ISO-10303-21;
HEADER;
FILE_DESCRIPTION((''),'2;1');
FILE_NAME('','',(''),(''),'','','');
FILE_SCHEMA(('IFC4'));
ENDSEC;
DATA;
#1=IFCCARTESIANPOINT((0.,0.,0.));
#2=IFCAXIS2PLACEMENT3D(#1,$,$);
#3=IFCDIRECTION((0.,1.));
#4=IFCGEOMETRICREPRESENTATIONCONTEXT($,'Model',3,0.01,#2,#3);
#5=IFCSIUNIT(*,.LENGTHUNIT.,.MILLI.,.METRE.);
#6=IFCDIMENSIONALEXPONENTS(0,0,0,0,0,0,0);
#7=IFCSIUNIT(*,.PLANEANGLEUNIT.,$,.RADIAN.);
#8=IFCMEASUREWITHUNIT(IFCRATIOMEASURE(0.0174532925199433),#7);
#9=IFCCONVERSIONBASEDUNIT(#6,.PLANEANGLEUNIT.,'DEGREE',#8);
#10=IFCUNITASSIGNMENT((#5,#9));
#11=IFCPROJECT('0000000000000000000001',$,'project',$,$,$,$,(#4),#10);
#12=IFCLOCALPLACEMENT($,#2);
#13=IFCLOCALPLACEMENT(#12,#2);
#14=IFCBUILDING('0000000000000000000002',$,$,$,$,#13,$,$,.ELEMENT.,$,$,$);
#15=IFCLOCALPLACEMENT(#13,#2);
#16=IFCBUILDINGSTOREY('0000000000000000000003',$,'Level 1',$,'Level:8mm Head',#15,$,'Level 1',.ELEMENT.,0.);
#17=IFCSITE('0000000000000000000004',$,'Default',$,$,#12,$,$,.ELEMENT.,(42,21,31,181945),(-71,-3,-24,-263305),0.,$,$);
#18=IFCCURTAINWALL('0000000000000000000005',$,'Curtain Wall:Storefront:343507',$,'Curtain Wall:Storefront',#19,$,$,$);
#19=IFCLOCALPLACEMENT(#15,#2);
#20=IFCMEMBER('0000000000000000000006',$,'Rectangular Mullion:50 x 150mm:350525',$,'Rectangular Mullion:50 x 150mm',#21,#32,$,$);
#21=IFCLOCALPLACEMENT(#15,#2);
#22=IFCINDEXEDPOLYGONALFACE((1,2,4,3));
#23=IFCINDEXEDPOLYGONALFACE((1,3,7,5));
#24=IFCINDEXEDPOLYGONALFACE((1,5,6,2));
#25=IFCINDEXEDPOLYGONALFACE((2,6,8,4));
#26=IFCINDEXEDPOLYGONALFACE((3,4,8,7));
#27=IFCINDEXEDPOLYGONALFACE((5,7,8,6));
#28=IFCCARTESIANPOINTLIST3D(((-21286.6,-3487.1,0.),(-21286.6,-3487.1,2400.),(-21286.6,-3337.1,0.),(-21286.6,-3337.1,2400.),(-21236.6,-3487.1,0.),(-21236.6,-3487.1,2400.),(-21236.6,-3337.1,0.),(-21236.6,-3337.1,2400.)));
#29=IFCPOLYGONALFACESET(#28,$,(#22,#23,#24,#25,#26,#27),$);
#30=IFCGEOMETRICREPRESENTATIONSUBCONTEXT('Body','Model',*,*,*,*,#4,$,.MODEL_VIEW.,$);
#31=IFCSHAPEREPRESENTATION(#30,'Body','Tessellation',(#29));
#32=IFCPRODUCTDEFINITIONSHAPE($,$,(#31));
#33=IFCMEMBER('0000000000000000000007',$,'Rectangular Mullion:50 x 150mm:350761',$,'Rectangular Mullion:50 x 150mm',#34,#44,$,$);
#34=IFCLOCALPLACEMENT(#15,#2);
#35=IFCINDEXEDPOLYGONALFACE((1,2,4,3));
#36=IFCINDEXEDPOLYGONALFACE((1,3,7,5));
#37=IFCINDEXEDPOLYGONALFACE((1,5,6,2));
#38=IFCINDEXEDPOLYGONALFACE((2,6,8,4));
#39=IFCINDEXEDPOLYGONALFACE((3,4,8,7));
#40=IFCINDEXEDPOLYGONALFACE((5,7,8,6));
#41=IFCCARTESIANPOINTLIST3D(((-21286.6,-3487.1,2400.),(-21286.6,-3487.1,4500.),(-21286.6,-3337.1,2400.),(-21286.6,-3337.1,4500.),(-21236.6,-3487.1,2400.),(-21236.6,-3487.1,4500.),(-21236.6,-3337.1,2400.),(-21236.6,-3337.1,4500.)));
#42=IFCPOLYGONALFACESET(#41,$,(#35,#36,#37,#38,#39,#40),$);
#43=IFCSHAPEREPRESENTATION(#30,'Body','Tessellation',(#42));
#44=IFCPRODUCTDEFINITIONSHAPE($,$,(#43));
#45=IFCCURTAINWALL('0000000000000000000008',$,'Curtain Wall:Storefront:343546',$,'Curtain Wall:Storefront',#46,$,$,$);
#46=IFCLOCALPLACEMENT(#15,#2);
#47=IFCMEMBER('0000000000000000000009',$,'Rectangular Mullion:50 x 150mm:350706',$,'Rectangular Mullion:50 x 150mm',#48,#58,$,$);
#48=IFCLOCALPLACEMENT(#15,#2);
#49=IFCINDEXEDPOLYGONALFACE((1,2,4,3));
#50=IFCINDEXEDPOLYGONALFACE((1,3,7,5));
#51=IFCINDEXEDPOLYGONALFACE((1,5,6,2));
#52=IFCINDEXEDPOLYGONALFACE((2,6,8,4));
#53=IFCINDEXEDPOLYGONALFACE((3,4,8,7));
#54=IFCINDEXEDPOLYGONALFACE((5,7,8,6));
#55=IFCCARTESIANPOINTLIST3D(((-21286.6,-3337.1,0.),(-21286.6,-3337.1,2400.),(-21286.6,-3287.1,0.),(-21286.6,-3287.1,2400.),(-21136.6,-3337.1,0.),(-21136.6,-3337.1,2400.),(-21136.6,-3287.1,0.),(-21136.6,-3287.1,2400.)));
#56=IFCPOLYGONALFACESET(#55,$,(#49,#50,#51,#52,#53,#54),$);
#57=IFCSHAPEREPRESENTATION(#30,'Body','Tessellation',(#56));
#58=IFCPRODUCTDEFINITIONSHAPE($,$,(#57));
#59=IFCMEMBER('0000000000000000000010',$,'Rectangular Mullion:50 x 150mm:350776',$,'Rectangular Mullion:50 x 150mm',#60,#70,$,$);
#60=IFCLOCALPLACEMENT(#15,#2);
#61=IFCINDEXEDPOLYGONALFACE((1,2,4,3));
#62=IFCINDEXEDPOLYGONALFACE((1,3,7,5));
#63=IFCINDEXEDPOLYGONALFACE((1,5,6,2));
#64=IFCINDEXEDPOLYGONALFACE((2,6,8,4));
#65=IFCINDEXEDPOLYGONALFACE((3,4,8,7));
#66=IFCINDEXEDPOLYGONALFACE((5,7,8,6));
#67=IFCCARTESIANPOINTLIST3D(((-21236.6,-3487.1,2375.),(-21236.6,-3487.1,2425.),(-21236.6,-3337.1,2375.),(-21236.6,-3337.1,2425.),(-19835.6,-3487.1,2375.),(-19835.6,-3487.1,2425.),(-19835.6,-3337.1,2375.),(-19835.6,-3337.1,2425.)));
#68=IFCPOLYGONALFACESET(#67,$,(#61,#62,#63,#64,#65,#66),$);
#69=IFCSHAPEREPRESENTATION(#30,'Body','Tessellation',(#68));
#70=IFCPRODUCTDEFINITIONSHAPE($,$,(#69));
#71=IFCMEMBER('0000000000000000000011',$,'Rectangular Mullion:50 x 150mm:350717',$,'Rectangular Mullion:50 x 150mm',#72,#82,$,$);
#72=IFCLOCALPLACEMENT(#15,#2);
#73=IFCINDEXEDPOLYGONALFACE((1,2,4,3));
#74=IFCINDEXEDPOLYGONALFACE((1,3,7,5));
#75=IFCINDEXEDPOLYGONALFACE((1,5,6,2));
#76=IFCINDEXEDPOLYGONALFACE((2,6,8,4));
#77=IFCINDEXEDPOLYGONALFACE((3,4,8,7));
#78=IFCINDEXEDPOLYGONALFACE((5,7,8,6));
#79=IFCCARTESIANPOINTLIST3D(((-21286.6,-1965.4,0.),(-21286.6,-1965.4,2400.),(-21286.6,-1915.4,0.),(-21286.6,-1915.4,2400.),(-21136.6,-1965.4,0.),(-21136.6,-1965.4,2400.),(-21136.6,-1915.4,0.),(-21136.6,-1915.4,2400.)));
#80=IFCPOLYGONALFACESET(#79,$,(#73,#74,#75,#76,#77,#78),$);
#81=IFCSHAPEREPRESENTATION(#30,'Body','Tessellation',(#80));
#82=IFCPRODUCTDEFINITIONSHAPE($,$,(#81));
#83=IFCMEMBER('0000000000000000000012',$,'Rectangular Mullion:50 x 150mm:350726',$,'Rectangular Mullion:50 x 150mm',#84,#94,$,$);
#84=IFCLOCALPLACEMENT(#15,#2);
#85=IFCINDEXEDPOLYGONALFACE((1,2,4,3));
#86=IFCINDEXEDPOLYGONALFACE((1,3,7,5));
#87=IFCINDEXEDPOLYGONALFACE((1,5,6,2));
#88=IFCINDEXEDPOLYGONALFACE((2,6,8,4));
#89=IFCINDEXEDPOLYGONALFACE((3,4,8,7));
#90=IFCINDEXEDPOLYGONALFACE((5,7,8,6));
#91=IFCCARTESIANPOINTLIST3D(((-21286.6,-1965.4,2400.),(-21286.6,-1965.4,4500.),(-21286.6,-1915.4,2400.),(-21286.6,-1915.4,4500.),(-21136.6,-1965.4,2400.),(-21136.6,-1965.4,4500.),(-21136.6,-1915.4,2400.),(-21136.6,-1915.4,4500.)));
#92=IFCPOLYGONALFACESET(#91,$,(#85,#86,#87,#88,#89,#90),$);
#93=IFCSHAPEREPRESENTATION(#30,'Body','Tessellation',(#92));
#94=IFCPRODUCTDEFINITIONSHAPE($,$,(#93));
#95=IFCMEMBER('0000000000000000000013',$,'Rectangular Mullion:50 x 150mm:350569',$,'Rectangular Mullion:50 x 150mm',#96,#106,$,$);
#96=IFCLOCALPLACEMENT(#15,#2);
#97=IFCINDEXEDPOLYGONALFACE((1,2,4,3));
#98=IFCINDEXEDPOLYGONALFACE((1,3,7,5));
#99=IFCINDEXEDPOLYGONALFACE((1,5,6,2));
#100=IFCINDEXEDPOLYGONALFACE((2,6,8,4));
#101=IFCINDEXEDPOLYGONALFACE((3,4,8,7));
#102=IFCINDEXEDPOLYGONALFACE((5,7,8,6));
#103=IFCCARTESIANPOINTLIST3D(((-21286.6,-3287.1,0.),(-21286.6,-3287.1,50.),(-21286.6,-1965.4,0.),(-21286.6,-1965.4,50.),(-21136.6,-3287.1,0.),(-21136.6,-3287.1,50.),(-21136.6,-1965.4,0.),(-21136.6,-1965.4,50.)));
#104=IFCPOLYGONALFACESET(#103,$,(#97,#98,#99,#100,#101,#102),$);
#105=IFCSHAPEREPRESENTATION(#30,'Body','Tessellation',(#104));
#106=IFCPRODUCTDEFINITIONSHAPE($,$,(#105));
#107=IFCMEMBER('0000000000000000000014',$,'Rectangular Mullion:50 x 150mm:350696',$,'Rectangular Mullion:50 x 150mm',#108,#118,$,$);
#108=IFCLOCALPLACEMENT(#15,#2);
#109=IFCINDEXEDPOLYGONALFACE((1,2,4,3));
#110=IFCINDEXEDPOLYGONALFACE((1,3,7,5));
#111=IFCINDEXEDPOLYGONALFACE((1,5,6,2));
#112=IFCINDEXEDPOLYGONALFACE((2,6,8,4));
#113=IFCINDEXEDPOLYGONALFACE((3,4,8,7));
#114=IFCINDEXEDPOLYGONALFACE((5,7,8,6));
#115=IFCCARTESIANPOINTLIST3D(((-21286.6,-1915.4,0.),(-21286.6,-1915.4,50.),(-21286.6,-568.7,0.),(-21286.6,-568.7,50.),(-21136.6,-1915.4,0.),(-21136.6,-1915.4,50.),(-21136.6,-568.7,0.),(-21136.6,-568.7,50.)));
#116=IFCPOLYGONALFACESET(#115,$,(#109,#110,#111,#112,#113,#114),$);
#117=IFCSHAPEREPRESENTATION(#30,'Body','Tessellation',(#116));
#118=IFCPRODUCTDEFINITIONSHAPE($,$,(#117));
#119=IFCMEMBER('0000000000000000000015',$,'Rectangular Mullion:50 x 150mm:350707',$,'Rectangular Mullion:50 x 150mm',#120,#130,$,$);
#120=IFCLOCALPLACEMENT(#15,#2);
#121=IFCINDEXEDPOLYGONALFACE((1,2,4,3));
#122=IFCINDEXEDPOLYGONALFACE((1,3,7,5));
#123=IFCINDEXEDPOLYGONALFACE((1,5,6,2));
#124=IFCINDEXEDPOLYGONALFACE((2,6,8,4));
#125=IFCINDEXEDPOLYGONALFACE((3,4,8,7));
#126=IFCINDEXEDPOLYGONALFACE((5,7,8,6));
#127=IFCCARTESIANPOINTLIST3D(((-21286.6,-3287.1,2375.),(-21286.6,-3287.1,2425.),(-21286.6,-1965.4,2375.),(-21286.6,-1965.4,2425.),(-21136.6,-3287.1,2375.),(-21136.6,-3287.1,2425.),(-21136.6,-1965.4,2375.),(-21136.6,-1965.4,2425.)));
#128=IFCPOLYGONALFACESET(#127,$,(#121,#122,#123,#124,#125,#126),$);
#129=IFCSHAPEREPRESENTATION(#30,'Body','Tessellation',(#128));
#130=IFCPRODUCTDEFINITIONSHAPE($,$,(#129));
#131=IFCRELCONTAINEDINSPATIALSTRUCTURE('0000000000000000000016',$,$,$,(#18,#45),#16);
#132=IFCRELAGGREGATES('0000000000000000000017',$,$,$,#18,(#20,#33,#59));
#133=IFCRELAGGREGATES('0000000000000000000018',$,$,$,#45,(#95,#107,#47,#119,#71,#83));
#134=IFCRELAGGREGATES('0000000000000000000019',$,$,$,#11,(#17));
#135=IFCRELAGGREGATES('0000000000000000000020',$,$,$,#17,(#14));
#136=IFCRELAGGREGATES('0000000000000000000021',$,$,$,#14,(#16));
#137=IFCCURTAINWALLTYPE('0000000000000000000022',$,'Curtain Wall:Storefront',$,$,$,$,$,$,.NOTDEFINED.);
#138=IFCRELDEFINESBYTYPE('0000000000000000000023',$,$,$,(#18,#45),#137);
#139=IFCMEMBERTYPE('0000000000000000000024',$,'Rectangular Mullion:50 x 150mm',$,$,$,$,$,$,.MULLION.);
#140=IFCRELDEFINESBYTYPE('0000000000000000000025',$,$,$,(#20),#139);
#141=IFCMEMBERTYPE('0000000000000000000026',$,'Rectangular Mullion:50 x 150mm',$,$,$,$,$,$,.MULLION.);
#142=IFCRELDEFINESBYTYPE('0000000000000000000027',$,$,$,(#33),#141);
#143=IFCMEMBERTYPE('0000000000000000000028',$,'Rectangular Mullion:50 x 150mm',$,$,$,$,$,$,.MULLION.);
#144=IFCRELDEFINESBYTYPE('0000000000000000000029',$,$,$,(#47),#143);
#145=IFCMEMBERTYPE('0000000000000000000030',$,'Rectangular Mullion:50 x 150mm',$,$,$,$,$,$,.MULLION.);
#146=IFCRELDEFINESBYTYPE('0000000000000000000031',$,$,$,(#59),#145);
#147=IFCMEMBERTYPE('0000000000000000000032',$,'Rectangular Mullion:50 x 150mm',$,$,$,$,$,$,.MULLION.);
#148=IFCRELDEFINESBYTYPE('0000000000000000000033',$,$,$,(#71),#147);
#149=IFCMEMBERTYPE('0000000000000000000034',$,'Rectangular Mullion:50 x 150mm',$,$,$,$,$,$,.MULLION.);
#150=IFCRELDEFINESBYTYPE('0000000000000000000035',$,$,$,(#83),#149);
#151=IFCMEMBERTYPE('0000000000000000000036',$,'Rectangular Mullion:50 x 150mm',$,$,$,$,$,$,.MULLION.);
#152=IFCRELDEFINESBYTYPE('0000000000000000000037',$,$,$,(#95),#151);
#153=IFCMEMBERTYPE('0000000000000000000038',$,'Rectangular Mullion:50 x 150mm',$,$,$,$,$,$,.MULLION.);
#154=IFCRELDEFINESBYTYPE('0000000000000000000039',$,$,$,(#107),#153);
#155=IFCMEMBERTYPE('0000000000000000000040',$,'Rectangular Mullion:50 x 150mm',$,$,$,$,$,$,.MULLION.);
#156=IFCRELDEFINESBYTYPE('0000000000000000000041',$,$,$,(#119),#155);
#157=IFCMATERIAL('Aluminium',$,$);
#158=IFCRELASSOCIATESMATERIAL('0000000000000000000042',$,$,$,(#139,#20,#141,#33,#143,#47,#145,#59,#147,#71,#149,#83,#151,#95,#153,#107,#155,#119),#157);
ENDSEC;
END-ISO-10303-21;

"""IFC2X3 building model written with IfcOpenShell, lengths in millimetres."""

from ifc_helpers import new_model, entity, si_unit, converted_unit, direction, frame, origin, origin_2d_with_axis, place, context, subcontext, project, spatial, rectangle, extrude, source, transform, mapped, material, type_object, type_shapes, element, aggregate, save


model = new_model("IFC2X3")

# Units and contexts
model_context = context("Model", 3, precision=0.01, world=origin(), true_north=direction((0.0, 1.0)))
body_context = subcontext(model_context, "Body", "Model", "MODEL_VIEW")
ifc_project = project(units=[si_unit("LENGTHUNIT", "METRE", prefix="MILLI"), converted_unit("PLANEANGLEUNIT", "DEGREE", entity("IfcRatioMeasure", 0.0174532925199433), si_unit("PLANEANGLEUNIT", "RADIAN"), dimensions=[0, 0, 0, 0, 0, 0, 0])], contexts=[model_context])

# Site, building, storey
site_placement = place(None, frame((0.0, 0.0, 0.0)))
site = spatial("IfcSite", under=ifc_project, at=site_placement, Name="Default", CompositionType="ELEMENT", RefLatitude=(42, 21, 31, 181945), RefLongitude=(-71, -3, -24, -263305), RefElevation=0.0)
building_placement = place(site_placement, origin())
building = spatial("IfcBuilding", under=site, at=building_placement, CompositionType="ELEMENT")
storey_placement = place(building_placement, origin())
storey = spatial("IfcBuildingStorey", under=building, at=storey_placement, Name="Level 1", ObjectType="Level:8mm Head", LongName="Level 1", CompositionType="ELEMENT", Elevation=0.0)

# Curtain wall, members
curtain_wall_type = type_object("IfcCurtainWallType", Name="Curtain Wall:Storefront", PredefinedType="NOTDEFINED")
curtain_wall_1_placement = place(storey_placement, origin())
curtain_wall_1 = element("IfcCurtainWall", 1, at=curtain_wall_1_placement, inside=storey, type_object=curtain_wall_type, Name="Curtain Wall:Storefront:343507", ObjectType="Curtain Wall:Storefront")
ifc_material_1 = material(Name="Aluminium")
member_type_1 = type_object("IfcMemberType", Name="Rectangular Mullion:50 x 150mm", PredefinedType="MULLION", material=ifc_material_1)
shared_shape_1 = source(origin(), body_context, "Body", "SweptSolid", [
    extrude(rectangle(XDim=150.0, YDim=50.0, at=origin_2d_with_axis()), frame((-25.0, 0.0, -2400.0), z_axis=(0.0, 0.0, 1.0), x_axis=(0.0, -1.0, 0.0)), (0.0, 0.0, 1.0), 2400.0),
])
type_shapes(member_type_1, [shared_shape_1])
member_1_placement = place(storey_placement, frame((-21286.6, -3412.1, 0.0), z_axis=(0.0, 0.0, -1.0), x_axis=(-1.0, 0.0, 0.0)))
member_1 = element("IfcMember", 2, at=member_1_placement, type_object=member_type_1, material=ifc_material_1, Name="Rectangular Mullion:50 x 150mm:350525", ObjectType="Rectangular Mullion:50 x 150mm", context=body_context, shape_type="MappedRepresentation", body=[
    mapped(shared_shape_1, transform((0.0, 0.0, 0.0), scale=1.0)),
])
member_type_2 = type_object("IfcMemberType", Name="Rectangular Mullion:50 x 150mm", PredefinedType="MULLION", material=ifc_material_1)
shared_shape_2 = source(origin(), body_context, "Body", "SweptSolid", [
    extrude(rectangle(XDim=150.0, YDim=50.0, at=origin_2d_with_axis()), frame((-25.0, 0.0, -2100.0), z_axis=(0.0, 0.0, 1.0), x_axis=(0.0, -1.0, 0.0)), (0.0, 0.0, 1.0), 2100.0),
])
type_shapes(member_type_2, [shared_shape_2])
member_2_placement = place(storey_placement, frame((-21286.6, -3412.1, 2400.0), z_axis=(0.0, 0.0, -1.0), x_axis=(-1.0, 0.0, 0.0)))
member_2 = element("IfcMember", 3, at=member_2_placement, type_object=member_type_2, material=ifc_material_1, Name="Rectangular Mullion:50 x 150mm:350761", ObjectType="Rectangular Mullion:50 x 150mm", context=body_context, shape_type="MappedRepresentation", body=[
    mapped(shared_shape_2, transform((0.0, 0.0, 0.0), scale=1.0)),
])

# Curtain wall, member
curtain_wall_2_placement = place(storey_placement, origin())
curtain_wall_2 = element("IfcCurtainWall", 4, at=curtain_wall_2_placement, inside=storey, type_object=curtain_wall_type, Name="Curtain Wall:Storefront:343546", ObjectType="Curtain Wall:Storefront")
member_type_3 = type_object("IfcMemberType", Name="Rectangular Mullion:50 x 150mm", PredefinedType="MULLION", material=ifc_material_1)
shared_shape_3 = source(origin(), body_context, "Body", "SweptSolid", [
    extrude(rectangle(XDim=150.0, YDim=50.0, at=origin_2d_with_axis()), frame((-25.0, 0.0, -2400.0), z_axis=(0.0, 0.0, 1.0), x_axis=(0.0, -1.0, 0.0)), (0.0, 0.0, 1.0), 2400.0),
])
type_shapes(member_type_3, [shared_shape_3])
member_3_placement = place(storey_placement, frame((-21211.6, -3337.1, 2400.0), z_axis=(0.0, 0.0, 1.0), x_axis=(0.0, -1.0, 0.0)))
member_3 = element("IfcMember", 5, at=member_3_placement, type_object=member_type_3, material=ifc_material_1, Name="Rectangular Mullion:50 x 150mm:350706", ObjectType="Rectangular Mullion:50 x 150mm", context=body_context, shape_type="MappedRepresentation", body=[
    mapped(shared_shape_3, transform((0.0, 0.0, 0.0), scale=1.0)),
])

# Members
member_type_4 = type_object("IfcMemberType", Name="Rectangular Mullion:50 x 150mm", PredefinedType="MULLION", material=ifc_material_1)
shared_shape_4 = source(origin(), body_context, "Body", "SweptSolid", [
    extrude(rectangle(XDim=150.0, YDim=50.0, at=origin_2d_with_axis()), frame((0.0, 0.0, -1401.0), z_axis=(0.0, 0.0, 1.0), x_axis=(0.0, -1.0, 0.0)), (0.0, 0.0, 1.0), 1401.0),
])
type_shapes(member_type_4, [shared_shape_4])
member_4_placement = place(storey_placement, frame((-21236.6, -3412.1, 2400.0), z_axis=(-1.0, 0.0, 0.0), x_axis=(0.0, 0.0, 1.0)))
member_4 = element("IfcMember", 6, at=member_4_placement, type_object=member_type_4, material=ifc_material_1, Name="Rectangular Mullion:50 x 150mm:350776", ObjectType="Rectangular Mullion:50 x 150mm", context=body_context, shape_type="MappedRepresentation", body=[
    mapped(shared_shape_4, transform((0.0, 0.0, 0.0), scale=1.0)),
])
member_type_5 = type_object("IfcMemberType", Name="Rectangular Mullion:50 x 150mm", PredefinedType="MULLION", material=ifc_material_1)
shared_shape_5 = source(origin(), body_context, "Body", "SweptSolid", [
    extrude(rectangle(XDim=150.0, YDim=50.0, at=origin_2d_with_axis()), frame((0.0, 0.0, -2400.0), z_axis=(0.0, 0.0, 1.0), x_axis=(0.0, -1.0, 0.0)), (0.0, 0.0, 1.0), 2400.0),
])
type_shapes(member_type_5, [shared_shape_5])
member_5_placement = place(storey_placement, frame((-21211.6, -1940.4, 0.0), z_axis=(0.0, 0.0, -1.0), x_axis=(0.0, 1.0, 0.0)))
member_5 = element("IfcMember", 7, at=member_5_placement, type_object=member_type_5, material=ifc_material_1, Name="Rectangular Mullion:50 x 150mm:350717", ObjectType="Rectangular Mullion:50 x 150mm", context=body_context, shape_type="MappedRepresentation", body=[
    mapped(shared_shape_5, transform((0.0, 0.0, 0.0), scale=1.0)),
])
member_type_6 = type_object("IfcMemberType", Name="Rectangular Mullion:50 x 150mm", PredefinedType="MULLION", material=ifc_material_1)
shared_shape_6 = source(origin(), body_context, "Body", "SweptSolid", [
    extrude(rectangle(XDim=150.0, YDim=50.0, at=origin_2d_with_axis()), frame((0.0, 0.0, -2100.0), z_axis=(0.0, 0.0, 1.0), x_axis=(0.0, -1.0, 0.0)), (0.0, 0.0, 1.0), 2100.0),
])
type_shapes(member_type_6, [shared_shape_6])
member_6_placement = place(storey_placement, frame((-21211.6, -1940.4, 2400.0), z_axis=(0.0, 0.0, -1.0), x_axis=(0.0, 1.0, 0.0)))
member_6 = element("IfcMember", 8, at=member_6_placement, type_object=member_type_6, material=ifc_material_1, Name="Rectangular Mullion:50 x 150mm:350726", ObjectType="Rectangular Mullion:50 x 150mm", context=body_context, shape_type="MappedRepresentation", body=[
    mapped(shared_shape_6, transform((0.0, 0.0, 0.0), scale=1.0)),
])
member_type_7 = type_object("IfcMemberType", Name="Rectangular Mullion:50 x 150mm", PredefinedType="MULLION", material=ifc_material_1)
shared_shape_7 = source(origin(), body_context, "Body", "SweptSolid", [
    extrude(rectangle(XDim=150.0, YDim=50.0, at=origin_2d_with_axis()), frame((-25.0, 0.0, -1321.7), z_axis=(0.0, 0.0, 1.0), x_axis=(0.0, -1.0, 0.0)), (0.0, 0.0, 1.0), 1321.7),
])
type_shapes(member_type_7, [shared_shape_7])
member_7_placement = place(storey_placement, frame((-21211.6, -3287.1, 0.0), z_axis=(0.0, -1.0, 0.0), x_axis=(0.0, 0.0, -1.0)))
member_7 = element("IfcMember", 9, at=member_7_placement, type_object=member_type_7, material=ifc_material_1, Name="Rectangular Mullion:50 x 150mm:350569", ObjectType="Rectangular Mullion:50 x 150mm", context=body_context, shape_type="MappedRepresentation", body=[
    mapped(shared_shape_7, transform((0.0, 0.0, 0.0), scale=1.0)),
])
member_type_8 = type_object("IfcMemberType", Name="Rectangular Mullion:50 x 150mm", PredefinedType="MULLION", material=ifc_material_1)
shared_shape_8 = source(origin(), body_context, "Body", "SweptSolid", [
    extrude(rectangle(XDim=150.0, YDim=50.0, at=origin_2d_with_axis()), frame((-25.0, 0.0, -1346.7), z_axis=(0.0, 0.0, 1.0), x_axis=(0.0, -1.0, 0.0)), (0.0, 0.0, 1.0), 1346.7),
])
type_shapes(member_type_8, [shared_shape_8])
member_8_placement = place(storey_placement, frame((-21211.6, -1915.4, 0.0), z_axis=(0.0, -1.0, 0.0), x_axis=(0.0, 0.0, -1.0)))
member_8 = element("IfcMember", 10, at=member_8_placement, type_object=member_type_8, material=ifc_material_1, Name="Rectangular Mullion:50 x 150mm:350696", ObjectType="Rectangular Mullion:50 x 150mm", context=body_context, shape_type="MappedRepresentation", body=[
    mapped(shared_shape_8, transform((0.0, 0.0, 0.0), scale=1.0)),
])
member_type_9 = type_object("IfcMemberType", Name="Rectangular Mullion:50 x 150mm", PredefinedType="MULLION", material=ifc_material_1)
shared_shape_9 = source(origin(), body_context, "Body", "SweptSolid", [
    extrude(rectangle(XDim=150.0, YDim=50.0, at=origin_2d_with_axis()), frame((0.0, 0.0, -1321.7), z_axis=(0.0, 0.0, 1.0), x_axis=(0.0, -1.0, 0.0)), (0.0, 0.0, 1.0), 1321.7),
])
type_shapes(member_type_9, [shared_shape_9])
member_9_placement = place(storey_placement, frame((-21211.6, -1965.4, 2400.0), z_axis=(0.0, 1.0, 0.0), x_axis=(0.0, 0.0, 1.0)))
member_9 = element("IfcMember", 11, at=member_9_placement, type_object=member_type_9, material=ifc_material_1, Name="Rectangular Mullion:50 x 150mm:350707", ObjectType="Rectangular Mullion:50 x 150mm", context=body_context, shape_type="MappedRepresentation", body=[
    mapped(shared_shape_9, transform((0.0, 0.0, 0.0), scale=1.0)),
])

aggregate(curtain_wall_1, [member_1, member_2, member_4])
aggregate(curtain_wall_2, [member_7, member_8, member_3, member_9, member_5, member_6])

save(model, "model.ifc")
